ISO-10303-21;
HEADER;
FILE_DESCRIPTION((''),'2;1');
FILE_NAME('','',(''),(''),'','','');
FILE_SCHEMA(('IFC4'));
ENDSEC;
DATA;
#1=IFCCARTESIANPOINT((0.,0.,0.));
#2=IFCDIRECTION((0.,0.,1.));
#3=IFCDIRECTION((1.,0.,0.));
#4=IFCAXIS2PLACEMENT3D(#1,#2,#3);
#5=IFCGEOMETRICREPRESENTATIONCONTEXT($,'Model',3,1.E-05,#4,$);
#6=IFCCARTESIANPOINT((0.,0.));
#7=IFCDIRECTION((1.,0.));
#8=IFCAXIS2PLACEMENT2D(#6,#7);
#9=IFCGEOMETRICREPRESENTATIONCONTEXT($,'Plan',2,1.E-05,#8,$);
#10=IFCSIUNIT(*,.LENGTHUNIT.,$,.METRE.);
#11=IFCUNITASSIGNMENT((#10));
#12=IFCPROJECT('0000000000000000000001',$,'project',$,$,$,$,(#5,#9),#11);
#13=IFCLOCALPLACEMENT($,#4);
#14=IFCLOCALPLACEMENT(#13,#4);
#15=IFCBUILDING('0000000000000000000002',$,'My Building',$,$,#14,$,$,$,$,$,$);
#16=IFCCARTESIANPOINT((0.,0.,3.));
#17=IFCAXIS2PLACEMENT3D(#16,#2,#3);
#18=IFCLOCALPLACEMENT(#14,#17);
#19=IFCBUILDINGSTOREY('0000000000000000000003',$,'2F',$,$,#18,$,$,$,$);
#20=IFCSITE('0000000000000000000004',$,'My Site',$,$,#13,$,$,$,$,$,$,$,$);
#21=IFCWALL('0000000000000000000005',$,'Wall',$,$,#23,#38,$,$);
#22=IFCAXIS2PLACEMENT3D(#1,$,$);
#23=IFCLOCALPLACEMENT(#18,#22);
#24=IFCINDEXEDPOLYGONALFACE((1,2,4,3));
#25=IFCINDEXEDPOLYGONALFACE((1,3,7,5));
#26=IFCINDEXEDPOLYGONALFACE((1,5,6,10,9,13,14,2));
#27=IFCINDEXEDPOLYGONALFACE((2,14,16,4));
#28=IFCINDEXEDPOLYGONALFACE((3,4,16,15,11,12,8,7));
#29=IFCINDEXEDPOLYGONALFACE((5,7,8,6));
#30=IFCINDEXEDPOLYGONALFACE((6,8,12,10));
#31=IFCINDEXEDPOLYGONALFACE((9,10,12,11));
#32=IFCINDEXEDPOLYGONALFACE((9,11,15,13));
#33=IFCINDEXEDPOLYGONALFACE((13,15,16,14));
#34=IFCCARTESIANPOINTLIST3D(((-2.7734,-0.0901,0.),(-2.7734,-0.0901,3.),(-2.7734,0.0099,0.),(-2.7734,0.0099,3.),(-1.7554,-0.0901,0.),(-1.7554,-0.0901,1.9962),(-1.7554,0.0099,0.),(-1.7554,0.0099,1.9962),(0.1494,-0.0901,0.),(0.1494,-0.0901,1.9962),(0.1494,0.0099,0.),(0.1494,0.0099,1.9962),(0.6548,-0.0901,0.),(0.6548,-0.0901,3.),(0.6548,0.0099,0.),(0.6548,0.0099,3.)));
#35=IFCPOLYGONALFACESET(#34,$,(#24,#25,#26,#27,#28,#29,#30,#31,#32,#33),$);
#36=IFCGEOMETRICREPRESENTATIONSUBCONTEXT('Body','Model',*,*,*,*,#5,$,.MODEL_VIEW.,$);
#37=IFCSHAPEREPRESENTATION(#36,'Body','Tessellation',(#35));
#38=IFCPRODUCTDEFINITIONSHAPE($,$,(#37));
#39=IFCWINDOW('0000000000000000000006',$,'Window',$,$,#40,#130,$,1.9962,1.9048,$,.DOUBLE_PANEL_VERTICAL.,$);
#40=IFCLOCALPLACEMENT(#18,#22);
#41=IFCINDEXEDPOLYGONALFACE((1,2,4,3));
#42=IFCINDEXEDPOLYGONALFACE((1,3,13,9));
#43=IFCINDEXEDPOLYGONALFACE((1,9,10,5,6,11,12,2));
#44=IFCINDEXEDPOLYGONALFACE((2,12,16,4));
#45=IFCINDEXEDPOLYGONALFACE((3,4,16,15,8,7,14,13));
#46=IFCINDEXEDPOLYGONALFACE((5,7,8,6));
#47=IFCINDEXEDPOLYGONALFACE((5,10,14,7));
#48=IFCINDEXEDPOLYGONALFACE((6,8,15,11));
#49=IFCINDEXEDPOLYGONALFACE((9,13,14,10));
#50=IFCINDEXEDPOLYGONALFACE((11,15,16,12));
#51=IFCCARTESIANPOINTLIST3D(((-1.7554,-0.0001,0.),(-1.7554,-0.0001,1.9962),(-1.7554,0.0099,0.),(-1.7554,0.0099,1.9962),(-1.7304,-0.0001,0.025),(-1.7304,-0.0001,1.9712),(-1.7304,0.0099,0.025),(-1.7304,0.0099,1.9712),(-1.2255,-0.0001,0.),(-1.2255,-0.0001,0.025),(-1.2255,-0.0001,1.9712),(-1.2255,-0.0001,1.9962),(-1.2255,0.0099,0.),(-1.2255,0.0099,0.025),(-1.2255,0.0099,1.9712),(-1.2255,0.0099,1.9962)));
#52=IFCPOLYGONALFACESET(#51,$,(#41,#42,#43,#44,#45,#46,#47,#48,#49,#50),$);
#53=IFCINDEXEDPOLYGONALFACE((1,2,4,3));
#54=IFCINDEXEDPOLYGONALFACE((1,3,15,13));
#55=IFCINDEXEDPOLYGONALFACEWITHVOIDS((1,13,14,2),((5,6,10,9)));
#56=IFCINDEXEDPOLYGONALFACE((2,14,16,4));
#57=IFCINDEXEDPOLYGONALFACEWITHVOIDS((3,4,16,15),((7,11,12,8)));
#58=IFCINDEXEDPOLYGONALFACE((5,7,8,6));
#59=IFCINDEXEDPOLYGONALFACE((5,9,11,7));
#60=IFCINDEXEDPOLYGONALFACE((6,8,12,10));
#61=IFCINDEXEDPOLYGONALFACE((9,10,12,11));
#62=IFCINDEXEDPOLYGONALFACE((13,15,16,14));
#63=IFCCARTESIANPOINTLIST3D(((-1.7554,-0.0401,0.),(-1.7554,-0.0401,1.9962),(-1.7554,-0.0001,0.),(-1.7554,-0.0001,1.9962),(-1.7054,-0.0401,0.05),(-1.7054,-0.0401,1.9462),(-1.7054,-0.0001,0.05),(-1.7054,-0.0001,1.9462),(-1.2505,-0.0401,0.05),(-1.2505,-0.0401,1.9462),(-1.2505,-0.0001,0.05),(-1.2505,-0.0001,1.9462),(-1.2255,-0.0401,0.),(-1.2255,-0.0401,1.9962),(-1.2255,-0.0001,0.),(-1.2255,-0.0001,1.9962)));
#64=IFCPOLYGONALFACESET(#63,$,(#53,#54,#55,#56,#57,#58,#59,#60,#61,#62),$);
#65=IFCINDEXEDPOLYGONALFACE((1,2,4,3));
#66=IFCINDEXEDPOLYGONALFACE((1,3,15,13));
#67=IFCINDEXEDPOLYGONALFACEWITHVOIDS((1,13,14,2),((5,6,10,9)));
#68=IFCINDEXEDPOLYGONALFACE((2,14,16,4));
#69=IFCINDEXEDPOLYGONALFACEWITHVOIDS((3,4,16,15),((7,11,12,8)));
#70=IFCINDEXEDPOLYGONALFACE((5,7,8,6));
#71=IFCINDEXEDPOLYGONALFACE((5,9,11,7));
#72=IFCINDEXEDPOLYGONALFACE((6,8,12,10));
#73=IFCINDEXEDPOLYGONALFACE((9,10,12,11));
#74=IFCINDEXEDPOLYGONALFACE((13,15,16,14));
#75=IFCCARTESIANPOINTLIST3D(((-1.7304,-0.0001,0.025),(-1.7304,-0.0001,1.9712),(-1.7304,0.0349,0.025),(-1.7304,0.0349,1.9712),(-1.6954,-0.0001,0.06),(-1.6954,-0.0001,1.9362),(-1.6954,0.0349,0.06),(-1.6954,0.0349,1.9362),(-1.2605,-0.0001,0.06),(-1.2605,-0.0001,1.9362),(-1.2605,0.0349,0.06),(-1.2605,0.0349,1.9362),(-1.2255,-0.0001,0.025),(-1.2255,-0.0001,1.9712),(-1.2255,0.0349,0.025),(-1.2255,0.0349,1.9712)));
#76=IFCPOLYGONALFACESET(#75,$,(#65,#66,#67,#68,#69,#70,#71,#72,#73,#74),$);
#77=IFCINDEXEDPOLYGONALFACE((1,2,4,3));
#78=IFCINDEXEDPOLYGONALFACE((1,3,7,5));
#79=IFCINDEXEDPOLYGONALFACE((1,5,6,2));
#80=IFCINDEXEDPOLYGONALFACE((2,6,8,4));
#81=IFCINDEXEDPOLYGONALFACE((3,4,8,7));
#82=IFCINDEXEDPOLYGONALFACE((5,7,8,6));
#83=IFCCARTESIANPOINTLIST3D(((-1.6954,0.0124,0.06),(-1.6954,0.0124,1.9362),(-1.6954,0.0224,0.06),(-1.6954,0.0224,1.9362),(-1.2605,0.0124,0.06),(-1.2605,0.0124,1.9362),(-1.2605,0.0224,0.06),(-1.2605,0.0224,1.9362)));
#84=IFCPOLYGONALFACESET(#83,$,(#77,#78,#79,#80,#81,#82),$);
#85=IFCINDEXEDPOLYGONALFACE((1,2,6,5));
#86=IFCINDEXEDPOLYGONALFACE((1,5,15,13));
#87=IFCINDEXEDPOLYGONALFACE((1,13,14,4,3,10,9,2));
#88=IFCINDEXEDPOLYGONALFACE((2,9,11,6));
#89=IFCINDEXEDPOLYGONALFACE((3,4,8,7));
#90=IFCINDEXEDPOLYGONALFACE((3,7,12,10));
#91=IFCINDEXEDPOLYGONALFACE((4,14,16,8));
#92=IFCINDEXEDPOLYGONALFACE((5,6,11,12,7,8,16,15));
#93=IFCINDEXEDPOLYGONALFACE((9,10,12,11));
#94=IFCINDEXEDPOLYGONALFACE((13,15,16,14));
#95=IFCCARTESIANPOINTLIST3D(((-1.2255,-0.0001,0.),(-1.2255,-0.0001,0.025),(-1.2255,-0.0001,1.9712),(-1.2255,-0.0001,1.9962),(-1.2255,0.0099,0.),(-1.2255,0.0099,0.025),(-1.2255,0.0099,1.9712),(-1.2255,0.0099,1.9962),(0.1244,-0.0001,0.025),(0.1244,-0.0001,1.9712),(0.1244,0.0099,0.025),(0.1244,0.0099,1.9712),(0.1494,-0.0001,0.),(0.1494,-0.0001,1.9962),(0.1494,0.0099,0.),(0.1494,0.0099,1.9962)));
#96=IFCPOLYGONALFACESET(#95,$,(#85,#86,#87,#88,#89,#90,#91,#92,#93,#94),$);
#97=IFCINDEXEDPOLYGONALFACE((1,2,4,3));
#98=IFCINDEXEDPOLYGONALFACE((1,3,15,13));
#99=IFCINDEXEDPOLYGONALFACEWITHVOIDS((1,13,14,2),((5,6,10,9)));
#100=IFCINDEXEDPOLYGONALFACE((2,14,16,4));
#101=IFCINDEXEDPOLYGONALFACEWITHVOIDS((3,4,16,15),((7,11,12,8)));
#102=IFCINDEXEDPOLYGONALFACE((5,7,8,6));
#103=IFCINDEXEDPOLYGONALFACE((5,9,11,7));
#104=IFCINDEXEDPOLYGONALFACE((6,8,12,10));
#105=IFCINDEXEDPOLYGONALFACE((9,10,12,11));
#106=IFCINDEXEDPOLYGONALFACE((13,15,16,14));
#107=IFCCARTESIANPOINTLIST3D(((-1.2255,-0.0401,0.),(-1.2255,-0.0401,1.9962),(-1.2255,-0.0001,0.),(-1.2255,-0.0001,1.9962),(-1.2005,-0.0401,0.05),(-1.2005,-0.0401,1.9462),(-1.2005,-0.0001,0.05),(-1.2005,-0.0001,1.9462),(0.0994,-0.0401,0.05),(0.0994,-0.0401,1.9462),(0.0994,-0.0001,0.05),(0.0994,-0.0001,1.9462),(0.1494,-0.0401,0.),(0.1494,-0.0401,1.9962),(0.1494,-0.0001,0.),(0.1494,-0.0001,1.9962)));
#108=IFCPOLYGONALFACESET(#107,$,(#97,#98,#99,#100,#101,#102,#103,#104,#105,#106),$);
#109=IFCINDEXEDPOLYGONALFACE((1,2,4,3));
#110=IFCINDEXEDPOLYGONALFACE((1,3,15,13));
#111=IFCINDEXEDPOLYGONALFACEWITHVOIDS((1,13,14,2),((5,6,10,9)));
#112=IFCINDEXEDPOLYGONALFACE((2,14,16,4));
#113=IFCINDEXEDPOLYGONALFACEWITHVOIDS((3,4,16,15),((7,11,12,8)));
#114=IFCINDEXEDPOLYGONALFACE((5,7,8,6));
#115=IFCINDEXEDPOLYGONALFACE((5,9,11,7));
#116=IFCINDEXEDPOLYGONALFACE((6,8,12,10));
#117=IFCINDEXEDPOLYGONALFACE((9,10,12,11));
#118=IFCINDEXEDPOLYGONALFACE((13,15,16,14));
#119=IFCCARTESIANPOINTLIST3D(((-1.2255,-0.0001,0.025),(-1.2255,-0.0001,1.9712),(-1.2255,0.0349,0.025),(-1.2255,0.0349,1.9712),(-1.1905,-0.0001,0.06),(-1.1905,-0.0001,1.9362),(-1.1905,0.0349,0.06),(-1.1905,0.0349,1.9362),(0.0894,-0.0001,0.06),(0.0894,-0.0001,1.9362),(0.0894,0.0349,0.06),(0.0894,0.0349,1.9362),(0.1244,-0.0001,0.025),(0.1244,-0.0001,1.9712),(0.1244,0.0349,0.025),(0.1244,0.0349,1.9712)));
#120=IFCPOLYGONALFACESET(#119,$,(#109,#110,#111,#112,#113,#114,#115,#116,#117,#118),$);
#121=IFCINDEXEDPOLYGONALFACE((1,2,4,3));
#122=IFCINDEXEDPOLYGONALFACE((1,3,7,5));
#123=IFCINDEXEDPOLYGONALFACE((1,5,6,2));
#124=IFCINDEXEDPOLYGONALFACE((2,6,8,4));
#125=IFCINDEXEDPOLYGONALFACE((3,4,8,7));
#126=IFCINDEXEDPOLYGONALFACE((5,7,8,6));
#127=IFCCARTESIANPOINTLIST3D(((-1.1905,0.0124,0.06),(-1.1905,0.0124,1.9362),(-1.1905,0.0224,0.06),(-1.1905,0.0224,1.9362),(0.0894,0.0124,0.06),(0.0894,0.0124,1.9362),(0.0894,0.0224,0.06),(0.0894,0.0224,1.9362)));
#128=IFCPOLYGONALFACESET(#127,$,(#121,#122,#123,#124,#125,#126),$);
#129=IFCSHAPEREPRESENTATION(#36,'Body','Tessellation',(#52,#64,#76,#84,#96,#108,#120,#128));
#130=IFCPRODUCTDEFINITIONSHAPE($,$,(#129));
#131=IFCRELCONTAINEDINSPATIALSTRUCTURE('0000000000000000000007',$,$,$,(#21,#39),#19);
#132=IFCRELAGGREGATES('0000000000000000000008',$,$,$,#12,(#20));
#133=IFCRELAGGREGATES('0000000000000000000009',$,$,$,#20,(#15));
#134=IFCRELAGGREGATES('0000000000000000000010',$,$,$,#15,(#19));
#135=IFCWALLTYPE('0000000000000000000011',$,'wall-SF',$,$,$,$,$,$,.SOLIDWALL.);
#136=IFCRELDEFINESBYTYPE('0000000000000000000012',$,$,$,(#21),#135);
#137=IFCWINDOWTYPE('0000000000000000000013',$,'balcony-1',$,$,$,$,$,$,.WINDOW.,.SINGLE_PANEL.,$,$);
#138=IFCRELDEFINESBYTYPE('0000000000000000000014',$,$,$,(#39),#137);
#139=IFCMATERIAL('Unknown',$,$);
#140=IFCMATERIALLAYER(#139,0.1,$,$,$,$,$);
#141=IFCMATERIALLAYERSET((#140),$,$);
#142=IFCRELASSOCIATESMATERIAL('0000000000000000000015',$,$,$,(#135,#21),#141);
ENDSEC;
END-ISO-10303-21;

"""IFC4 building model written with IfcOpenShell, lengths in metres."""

from ifc_helpers import new_model, entity, si_unit, frame, origin_with_axes, origin_2d_with_axis, place, context, subcontext, project, spatial, line, indexed_curve, outline, extrude, shape, source, transform, mapped, material, layer, layer_set, layer_usage, type_object, type_shapes, element, fill, save


model = new_model("IFC4")

# Units and contexts
model_context = context("Model", 3, precision=1e-05, world=origin_with_axes())
plan_context = context("Plan", 2, precision=1e-05, world=origin_2d_with_axis())
body_context_1 = subcontext(model_context, "Body", "Model", "MODEL_VIEW")
body_context_2 = subcontext(plan_context, "Body", "Plan", "PLAN_VIEW")
ifc_project = project(units=[si_unit("LENGTHUNIT", "METRE")], contexts=[model_context, plan_context])

# Site, building, storey
site_placement = place(None, origin_with_axes())
site = spatial("IfcSite", under=ifc_project, at=site_placement, Name="My Site")
building_placement = place(site_placement, origin_with_axes())
building = spatial("IfcBuilding", under=site, at=building_placement, Name="My Building")
storey_placement = place(building_placement, frame((0.0, 0.0, 3.0), z_axis=(0.0, 0.0, 1.0), x_axis=(1.0, 0.0, 0.0)))
storey = spatial("IfcBuildingStorey", under=building, at=storey_placement, Name="2F")

# Shared definitions
ifc_material = material(Name="Unknown")

# Shared definitions
ifc_layer_1 = layer(ifc_material, 0.1)
ifc_layer_set_1 = layer_set([ifc_layer_1])
wall_type = type_object("IfcWallType", Name="wall-SF", PredefinedType="SOLIDWALL", material=ifc_layer_set_1)

# Wall, opening, window
ifc_layer_usage_1 = layer_usage(ifc_layer_set_1, "AXIS2", "POSITIVE", 0.0)
wall_1_placement = place(storey_placement, frame((-2.7734, -0.0901, 0.0), z_axis=(0.0, 0.0, 1.0), x_axis=(1.0, 0.0, 0.0)))
wall_1 = element("IfcWall", 1, at=wall_1_placement, inside=storey, type_object=wall_type, material=ifc_layer_usage_1, Name="Wall", context=body_context_1, shape_type="SweptSolid", body=[
    extrude(outline(indexed_curve([(0.0, 0.0), (0.0, 0.1), (3.4282, 0.1), (3.4282, 0.0)], segments=[line(1, 2, 3, 4, 1)])), origin_with_axes(), (0.0, 0.0, 1.0), 3.0),
])
shared_shape_1 = source(origin_with_axes(), body_context_1, "Body", "SweptSolid", [
    extrude(outline(indexed_curve([(0.0, 0.0), (1.9048, 0.0), (1.9048, 1.9962), (0.0, 1.9962)], segments=[line(1, 2, 3, 4, 1)])), frame((0.0, -0.6, 0.0), z_axis=(0.0, -1.0, 0.0), x_axis=(1.0, 0.0, 0.0)), (0.0, 0.0, -1.0), 1.2),
])
opening_1_placement = place(wall_1_placement, frame((1.018, 0.0, 0.0), z_axis=(0.0, 0.0, 1.0), x_axis=(1.0, 0.0, 0.0)))
opening_1 = element("IfcOpeningElement", 2, at=opening_1_placement, cuts=wall_1, PredefinedType="OPENING", context=body_context_1, shape_type="MappedRepresentation", body=[
    mapped(shared_shape_1, transform((0.0, 0.0, 0.0), x_axis=(1.0, 0.0, 0.0), y_axis=(0.0, 1.0, 0.0), z_axis=(0.0, 0.0, 1.0), scale=1.0)),
])
window_type_1 = type_object("IfcWindowType", Name="balcony-1", PartitioningType="SINGLE_PANEL", PredefinedType="WINDOW")
shared_shape_2 = source(origin_with_axes(), body_context_1, "Body", "SweptSolid", [
    extrude(outline(indexed_curve([(0.5299, 0.0), (0.0, 0.0), (0.0, 1.9962), (0.5299, 1.9962), (0.5299, 1.9712), (0.025, 1.9712), (0.025, 0.025), (0.5299, 0.025)], segments=[line(1, 2, 3, 4, 5, 6, 7, 8, 1)])), frame((0.0, 0.09, 0.0), z_axis=(0.0, -1.0, 0.0), x_axis=(1.0, 0.0, 0.0)), (0.0, 0.0, -1.0), 0.01),
    extrude(outline(indexed_curve([(0.0, 0.0), (0.5299, 0.0), (0.5299, 1.9962), (0.0, 1.9962)], segments=[line(1, 2, 3, 4, 1)]), holes=[indexed_curve([(0.05, 0.05), (0.5049, 0.05), (0.5049, 1.9462), (0.05, 1.9462)], segments=[line(1, 2, 3, 4, 1)])]), frame((0.0, 0.05, 0.0), z_axis=(0.0, -1.0, 0.0), x_axis=(1.0, 0.0, 0.0)), (0.0, 0.0, -1.0), 0.04),
    extrude(outline(indexed_curve([(0.0, 0.0), (0.5049, 0.0), (0.5049, 1.9462), (0.0, 1.9462)], segments=[line(1, 2, 3, 4, 1)]), holes=[indexed_curve([(0.035, 0.035), (0.4699, 0.035), (0.4699, 1.9112), (0.035, 1.9112)], segments=[line(1, 2, 3, 4, 1)])]), frame((0.025, 0.09, 0.025), z_axis=(0.0, -1.0, 0.0), x_axis=(1.0, 0.0, 0.0)), (0.0, 0.0, -1.0), 0.035),
    extrude(outline(indexed_curve([(0.035, 0.035), (0.4699, 0.035), (0.4699, 1.9112), (0.035, 1.9112)], segments=[line(1, 2, 3, 4, 1)])), frame((0.025, 0.1025, 0.025), z_axis=(0.0, -1.0, 0.0), x_axis=(1.0, 0.0, 0.0)), (0.0, 0.0, -1.0), 0.01),
    extrude(outline(indexed_curve([(0.0, 1.9962), (1.3749, 1.9962), (1.3749, 0.0), (0.0, 0.0), (0.0, 0.025), (1.3499, 0.025), (1.3499, 1.9712), (0.0, 1.9712)], segments=[line(1, 2, 3, 4, 5, 6, 7, 8, 1)])), frame((0.5299, 0.09, 0.0), z_axis=(0.0, -1.0, 0.0), x_axis=(1.0, 0.0, 0.0)), (0.0, 0.0, -1.0), 0.01),
    extrude(outline(indexed_curve([(0.0, 0.0), (1.3749, 0.0), (1.3749, 1.9962), (0.0, 1.9962)], segments=[line(1, 2, 3, 4, 1)]), holes=[indexed_curve([(0.025, 0.05), (1.3249, 0.05), (1.3249, 1.9462), (0.025, 1.9462)], segments=[line(1, 2, 3, 4, 1)])]), frame((0.5299, 0.05, 0.0), z_axis=(0.0, -1.0, 0.0), x_axis=(1.0, 0.0, 0.0)), (0.0, 0.0, -1.0), 0.04),
    extrude(outline(indexed_curve([(0.0, 0.0), (1.3499, 0.0), (1.3499, 1.9462), (0.0, 1.9462)], segments=[line(1, 2, 3, 4, 1)]), holes=[indexed_curve([(0.035, 0.035), (1.3149, 0.035), (1.3149, 1.9112), (0.035, 1.9112)], segments=[line(1, 2, 3, 4, 1)])]), frame((0.5299, 0.09, 0.025), z_axis=(0.0, -1.0, 0.0), x_axis=(1.0, 0.0, 0.0)), (0.0, 0.0, -1.0), 0.035),
    extrude(outline(indexed_curve([(0.035, 0.035), (1.3149, 0.035), (1.3149, 1.9112), (0.035, 1.9112)], segments=[line(1, 2, 3, 4, 1)])), frame((0.5299, 0.1025, 0.025), z_axis=(0.0, -1.0, 0.0), x_axis=(1.0, 0.0, 0.0)), (0.0, 0.0, -1.0), 0.01),
])
shared_shape_3 = source(origin_with_axes(), body_context_2, "Body", "Curve2D", [
    entity("IfcIndexedPolyCurve", entity("IfcCartesianPointList2D", [[0.05, 0.05], [0.5049, 0.05]])),
    entity("IfcIndexedPolyCurve", entity("IfcCartesianPointList2D", [[0.0, 0.1], [0.025, 0.1], [0.025, 0.09], [0.05, 0.09], [0.05, 0.05], [0.0, 0.05]]), [entity("IfcLineIndex", [1, 2, 3, 4, 5, 6, 1])]),
    entity("IfcIndexedPolyCurve", entity("IfcCartesianPointList2D", [[0.5299, 0.1], [0.5299, 0.1], [0.5299, 0.09], [0.5049, 0.09], [0.5049, 0.05], [0.5299, 0.05]])),
    entity("IfcIndexedPolyCurve", entity("IfcCartesianPointList2D", [[0.025, 0.09], [0.06, 0.09], [0.06, 0.125], [0.025, 0.125]]), [entity("IfcLineIndex", [1, 2, 3, 4, 1])]),
    entity("IfcIndexedPolyCurve", entity("IfcCartesianPointList2D", [[0.5299, 0.09], [0.4949, 0.09], [0.4949, 0.125], [0.5299, 0.125]]), [entity("IfcLineIndex", [1, 2, 3, 4, 1])]),
    entity("IfcIndexedPolyCurve", entity("IfcCartesianPointList2D", [[0.06, 0.09], [0.4949, 0.09]])),
    entity("IfcIndexedPolyCurve", entity("IfcCartesianPointList2D", [[0.06, 0.125], [0.4949, 0.125]])),
    entity("IfcIndexedPolyCurve", entity("IfcCartesianPointList2D", [[0.06, 0.1075], [0.4949, 0.1075]])),
    entity("IfcIndexedPolyCurve", entity("IfcCartesianPointList2D", [[0.5549, 0.05], [1.8548, 0.05]])),
    entity("IfcIndexedPolyCurve", entity("IfcCartesianPointList2D", [[0.5299, 0.1], [0.5299, 0.1], [0.5299, 0.09], [0.5549, 0.09], [0.5549, 0.05], [0.5299, 0.05]])),
    entity("IfcIndexedPolyCurve", entity("IfcCartesianPointList2D", [[1.9048, 0.1], [1.8798, 0.1], [1.8798, 0.09], [1.8548, 0.09], [1.8548, 0.05], [1.9048, 0.05]]), [entity("IfcLineIndex", [1, 2, 3, 4, 5, 6, 1])]),
    entity("IfcIndexedPolyCurve", entity("IfcCartesianPointList2D", [[0.5299, 0.09], [0.5649, 0.09], [0.5649, 0.125], [0.5299, 0.125]]), [entity("IfcLineIndex", [1, 2, 3, 4, 1])]),
    entity("IfcIndexedPolyCurve", entity("IfcCartesianPointList2D", [[1.8798, 0.09], [1.8448, 0.09], [1.8448, 0.125], [1.8798, 0.125]]), [entity("IfcLineIndex", [1, 2, 3, 4, 1])]),
    entity("IfcIndexedPolyCurve", entity("IfcCartesianPointList2D", [[0.5649, 0.09], [1.8448, 0.09]])),
    entity("IfcIndexedPolyCurve", entity("IfcCartesianPointList2D", [[0.5649, 0.125], [1.8448, 0.125]])),
    entity("IfcIndexedPolyCurve", entity("IfcCartesianPointList2D", [[0.5649, 0.1075], [1.8448, 0.1075]])),
])
type_shapes(window_type_1, [shared_shape_2, shared_shape_3])
window_1_placement = place(opening_1_placement, origin_with_axes())
window_1 = element("IfcWindow", 3, at=window_1_placement, inside=storey, type_object=window_type_1, Name="Window", OverallHeight=1.9962, OverallWidth=1.9048, PartitioningType="DOUBLE_PANEL_VERTICAL", shapes=[
    shape(body_context_1, "Body", "MappedRepresentation", [mapped(shared_shape_2, transform((0.0, 0.0, 0.0), x_axis=(1.0, 0.0, 0.0), y_axis=(0.0, 1.0, 0.0), z_axis=(0.0, 0.0, 1.0), scale=1.0))]),
    shape(body_context_2, "Body", "MappedRepresentation", [mapped(shared_shape_3, transform((0.0, 0.0, 0.0), x_axis=(1.0, 0.0, 0.0), y_axis=(0.0, 1.0, 0.0), z_axis=(0.0, 0.0, 1.0), scale=1.0))]),
])
fill(opening_1, window_1)

save(model, "model.ifc")
